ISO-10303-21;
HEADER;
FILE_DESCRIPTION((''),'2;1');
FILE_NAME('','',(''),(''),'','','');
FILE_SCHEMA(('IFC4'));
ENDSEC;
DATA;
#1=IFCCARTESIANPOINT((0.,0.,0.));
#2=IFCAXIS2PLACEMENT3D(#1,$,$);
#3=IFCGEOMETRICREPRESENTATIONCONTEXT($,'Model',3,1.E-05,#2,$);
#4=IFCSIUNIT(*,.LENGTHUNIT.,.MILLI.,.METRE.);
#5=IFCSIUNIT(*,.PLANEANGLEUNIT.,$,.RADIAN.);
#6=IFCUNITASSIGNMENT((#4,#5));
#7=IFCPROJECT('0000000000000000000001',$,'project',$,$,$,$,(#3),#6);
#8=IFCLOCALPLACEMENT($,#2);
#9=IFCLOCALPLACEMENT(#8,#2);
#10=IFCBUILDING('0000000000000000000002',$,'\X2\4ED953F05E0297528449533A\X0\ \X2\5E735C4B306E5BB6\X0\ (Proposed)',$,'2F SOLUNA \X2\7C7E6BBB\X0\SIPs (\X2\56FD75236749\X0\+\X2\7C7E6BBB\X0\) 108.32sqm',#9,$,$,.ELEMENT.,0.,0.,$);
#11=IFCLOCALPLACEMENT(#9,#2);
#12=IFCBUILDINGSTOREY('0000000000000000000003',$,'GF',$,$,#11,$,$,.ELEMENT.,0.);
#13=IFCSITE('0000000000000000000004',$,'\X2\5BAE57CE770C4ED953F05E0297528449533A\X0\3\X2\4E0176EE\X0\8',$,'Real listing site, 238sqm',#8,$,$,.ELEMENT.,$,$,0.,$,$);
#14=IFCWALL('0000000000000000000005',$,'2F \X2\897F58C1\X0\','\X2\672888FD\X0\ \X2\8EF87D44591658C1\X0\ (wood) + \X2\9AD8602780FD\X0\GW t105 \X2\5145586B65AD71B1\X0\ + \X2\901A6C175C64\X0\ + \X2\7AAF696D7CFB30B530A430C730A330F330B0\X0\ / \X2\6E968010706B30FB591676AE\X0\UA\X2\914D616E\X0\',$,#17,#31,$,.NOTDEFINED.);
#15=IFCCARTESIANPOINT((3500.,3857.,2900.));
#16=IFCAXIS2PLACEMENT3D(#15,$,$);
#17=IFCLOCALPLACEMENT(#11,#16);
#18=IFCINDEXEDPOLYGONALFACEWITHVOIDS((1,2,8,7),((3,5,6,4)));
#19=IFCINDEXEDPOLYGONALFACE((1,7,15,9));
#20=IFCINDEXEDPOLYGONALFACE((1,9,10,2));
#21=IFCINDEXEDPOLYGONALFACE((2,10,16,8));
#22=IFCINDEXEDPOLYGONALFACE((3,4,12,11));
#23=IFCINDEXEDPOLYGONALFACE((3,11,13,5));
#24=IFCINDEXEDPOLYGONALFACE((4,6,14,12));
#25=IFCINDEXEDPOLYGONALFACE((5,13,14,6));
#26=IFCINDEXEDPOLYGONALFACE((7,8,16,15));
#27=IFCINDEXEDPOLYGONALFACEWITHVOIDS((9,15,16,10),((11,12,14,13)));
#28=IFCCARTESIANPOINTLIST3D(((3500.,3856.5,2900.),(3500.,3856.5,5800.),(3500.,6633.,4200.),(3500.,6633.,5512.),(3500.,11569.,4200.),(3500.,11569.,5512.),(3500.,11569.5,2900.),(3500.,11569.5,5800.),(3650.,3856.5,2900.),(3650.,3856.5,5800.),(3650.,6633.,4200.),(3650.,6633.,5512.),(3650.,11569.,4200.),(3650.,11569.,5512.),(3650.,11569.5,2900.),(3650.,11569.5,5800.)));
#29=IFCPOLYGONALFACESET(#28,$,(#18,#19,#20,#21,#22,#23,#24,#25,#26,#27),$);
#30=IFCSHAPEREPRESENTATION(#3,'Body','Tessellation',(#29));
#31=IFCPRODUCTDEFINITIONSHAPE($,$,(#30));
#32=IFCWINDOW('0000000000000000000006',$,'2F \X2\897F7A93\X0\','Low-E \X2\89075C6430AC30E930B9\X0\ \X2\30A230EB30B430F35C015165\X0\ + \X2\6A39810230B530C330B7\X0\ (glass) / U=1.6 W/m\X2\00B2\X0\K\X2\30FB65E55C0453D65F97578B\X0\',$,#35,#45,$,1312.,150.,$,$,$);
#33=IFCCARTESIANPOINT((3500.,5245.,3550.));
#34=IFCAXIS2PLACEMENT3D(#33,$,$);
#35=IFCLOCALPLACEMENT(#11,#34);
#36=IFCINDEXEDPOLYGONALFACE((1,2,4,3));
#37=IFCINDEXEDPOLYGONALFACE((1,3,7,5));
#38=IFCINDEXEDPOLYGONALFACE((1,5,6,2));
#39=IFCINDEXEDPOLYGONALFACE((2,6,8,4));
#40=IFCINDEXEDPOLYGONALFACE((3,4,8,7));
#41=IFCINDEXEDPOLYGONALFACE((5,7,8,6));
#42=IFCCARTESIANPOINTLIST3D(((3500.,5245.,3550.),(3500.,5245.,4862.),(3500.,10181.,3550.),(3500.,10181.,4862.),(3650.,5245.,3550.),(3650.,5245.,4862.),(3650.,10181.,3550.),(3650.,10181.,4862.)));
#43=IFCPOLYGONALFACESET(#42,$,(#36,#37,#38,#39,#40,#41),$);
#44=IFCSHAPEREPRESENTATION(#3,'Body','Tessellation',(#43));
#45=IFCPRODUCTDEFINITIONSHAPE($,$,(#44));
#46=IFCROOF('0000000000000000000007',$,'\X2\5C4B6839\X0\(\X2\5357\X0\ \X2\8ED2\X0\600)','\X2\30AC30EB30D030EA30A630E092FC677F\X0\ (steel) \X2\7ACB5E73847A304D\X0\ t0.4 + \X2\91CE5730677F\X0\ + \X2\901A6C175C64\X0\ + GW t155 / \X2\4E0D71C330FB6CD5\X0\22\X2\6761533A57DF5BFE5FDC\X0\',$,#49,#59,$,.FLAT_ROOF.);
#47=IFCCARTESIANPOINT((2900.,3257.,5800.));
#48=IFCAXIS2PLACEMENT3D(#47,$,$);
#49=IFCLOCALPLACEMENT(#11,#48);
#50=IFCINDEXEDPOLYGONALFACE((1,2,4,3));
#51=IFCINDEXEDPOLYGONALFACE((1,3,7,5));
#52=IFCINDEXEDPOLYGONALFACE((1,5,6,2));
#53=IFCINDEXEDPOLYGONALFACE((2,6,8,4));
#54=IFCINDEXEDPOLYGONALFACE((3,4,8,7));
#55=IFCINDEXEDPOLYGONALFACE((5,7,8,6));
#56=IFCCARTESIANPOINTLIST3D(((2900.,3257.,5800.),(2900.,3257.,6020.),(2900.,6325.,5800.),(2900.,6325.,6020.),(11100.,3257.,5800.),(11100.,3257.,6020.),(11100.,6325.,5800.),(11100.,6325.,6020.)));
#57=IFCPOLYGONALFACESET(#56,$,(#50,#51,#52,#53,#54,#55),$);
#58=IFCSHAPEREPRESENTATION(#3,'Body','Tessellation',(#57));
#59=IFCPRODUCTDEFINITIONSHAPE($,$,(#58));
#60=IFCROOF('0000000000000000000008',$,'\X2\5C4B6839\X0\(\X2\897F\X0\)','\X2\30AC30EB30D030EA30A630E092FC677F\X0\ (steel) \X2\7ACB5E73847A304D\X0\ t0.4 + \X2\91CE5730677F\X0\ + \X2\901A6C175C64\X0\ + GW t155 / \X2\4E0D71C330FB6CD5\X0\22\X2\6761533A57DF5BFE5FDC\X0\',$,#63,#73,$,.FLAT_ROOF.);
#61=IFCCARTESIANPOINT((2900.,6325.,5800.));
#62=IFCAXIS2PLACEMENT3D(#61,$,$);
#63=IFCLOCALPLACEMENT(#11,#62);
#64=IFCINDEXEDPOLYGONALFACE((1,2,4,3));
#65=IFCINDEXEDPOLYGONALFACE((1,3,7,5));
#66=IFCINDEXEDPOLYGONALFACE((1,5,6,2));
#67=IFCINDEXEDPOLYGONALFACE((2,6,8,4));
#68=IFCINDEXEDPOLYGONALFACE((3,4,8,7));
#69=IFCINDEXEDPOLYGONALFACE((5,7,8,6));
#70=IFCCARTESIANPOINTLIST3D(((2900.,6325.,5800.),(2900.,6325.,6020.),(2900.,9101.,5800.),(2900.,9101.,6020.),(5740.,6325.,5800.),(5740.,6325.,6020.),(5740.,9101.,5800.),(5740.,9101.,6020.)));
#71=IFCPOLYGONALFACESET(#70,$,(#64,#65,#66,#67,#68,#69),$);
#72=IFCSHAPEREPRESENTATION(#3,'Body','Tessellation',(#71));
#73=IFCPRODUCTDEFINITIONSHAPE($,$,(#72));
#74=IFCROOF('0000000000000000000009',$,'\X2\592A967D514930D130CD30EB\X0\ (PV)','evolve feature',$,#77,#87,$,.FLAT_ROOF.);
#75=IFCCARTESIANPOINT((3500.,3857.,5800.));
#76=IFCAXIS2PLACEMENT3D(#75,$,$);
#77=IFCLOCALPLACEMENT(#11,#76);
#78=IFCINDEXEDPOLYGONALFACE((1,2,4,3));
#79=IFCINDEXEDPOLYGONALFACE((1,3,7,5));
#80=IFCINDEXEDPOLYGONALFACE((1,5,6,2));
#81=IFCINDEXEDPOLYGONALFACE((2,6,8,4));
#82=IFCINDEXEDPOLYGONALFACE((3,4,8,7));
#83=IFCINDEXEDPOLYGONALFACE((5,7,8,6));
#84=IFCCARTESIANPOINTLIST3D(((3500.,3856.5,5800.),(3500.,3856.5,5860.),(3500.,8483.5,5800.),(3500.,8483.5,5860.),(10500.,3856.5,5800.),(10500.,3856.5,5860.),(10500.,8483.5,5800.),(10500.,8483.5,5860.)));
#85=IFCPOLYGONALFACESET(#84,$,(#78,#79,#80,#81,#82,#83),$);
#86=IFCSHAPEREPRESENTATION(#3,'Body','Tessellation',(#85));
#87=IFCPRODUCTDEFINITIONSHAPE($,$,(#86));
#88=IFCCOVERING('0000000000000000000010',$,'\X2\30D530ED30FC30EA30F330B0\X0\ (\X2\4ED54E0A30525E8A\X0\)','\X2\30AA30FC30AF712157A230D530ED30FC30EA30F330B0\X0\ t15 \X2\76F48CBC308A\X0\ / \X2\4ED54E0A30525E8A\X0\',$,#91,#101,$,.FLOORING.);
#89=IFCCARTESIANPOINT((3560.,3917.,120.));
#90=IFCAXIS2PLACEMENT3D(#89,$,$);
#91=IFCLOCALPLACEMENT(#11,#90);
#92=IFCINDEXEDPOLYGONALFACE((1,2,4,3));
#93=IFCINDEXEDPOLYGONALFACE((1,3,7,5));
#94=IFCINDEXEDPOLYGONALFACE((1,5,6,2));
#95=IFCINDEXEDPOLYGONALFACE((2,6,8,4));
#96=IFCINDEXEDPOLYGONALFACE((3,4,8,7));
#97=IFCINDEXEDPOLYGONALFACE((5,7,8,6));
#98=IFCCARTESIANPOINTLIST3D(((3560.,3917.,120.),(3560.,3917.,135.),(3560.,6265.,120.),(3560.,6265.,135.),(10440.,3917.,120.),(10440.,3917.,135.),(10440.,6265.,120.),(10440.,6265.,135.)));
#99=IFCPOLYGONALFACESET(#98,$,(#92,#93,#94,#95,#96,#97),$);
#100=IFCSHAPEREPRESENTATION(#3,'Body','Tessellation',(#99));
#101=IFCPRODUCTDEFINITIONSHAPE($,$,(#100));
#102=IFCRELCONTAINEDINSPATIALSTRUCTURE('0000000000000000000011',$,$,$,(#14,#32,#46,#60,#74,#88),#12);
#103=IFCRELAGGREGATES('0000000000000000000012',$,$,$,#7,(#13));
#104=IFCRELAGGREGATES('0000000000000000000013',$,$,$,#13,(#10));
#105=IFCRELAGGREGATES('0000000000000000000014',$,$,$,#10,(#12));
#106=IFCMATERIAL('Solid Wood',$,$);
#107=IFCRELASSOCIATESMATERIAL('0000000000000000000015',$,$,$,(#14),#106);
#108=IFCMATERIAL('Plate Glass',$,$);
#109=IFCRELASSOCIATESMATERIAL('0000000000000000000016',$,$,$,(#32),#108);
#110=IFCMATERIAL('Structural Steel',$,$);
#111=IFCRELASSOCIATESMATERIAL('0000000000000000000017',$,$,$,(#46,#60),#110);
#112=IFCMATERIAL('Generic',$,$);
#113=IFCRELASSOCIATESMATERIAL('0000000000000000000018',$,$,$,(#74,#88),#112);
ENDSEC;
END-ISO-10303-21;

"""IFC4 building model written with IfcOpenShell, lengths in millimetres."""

from ifc_helpers import new_model, si_unit, frame, frame_2d, origin, place, context, project, spatial, rectangle, extrude, material, element, fill, save


model = new_model("IFC4")

# Units and contexts
model_context = context("Model", 3, precision=1e-05, world=origin())
ifc_project = project(units=[si_unit("LENGTHUNIT", "METRE", prefix="MILLI"), si_unit("PLANEANGLEUNIT", "RADIAN")], contexts=[model_context])

# Site, building, storey
site_placement = place(None, origin())
site = spatial("IfcSite", under=ifc_project, at=site_placement, Name="宮城県仙台市青葉区3丁目8", ObjectType="Real listing site, 238sqm", CompositionType="ELEMENT", RefElevation=0.0)
building_placement = place(site_placement, origin())
building = spatial("IfcBuilding", under=site, at=building_placement, Name="仙台市青葉区 平屋の家 (Proposed)", ObjectType="2F SOLUNA 籾殻SIPs (国産杉+籾殻) 108.32sqm", CompositionType="ELEMENT", ElevationOfRefHeight=0.0, ElevationOfTerrain=0.0)
storey_placement = place(building_placement, origin())
storey = spatial("IfcBuildingStorey", under=building, at=storey_placement, Name="GF", CompositionType="ELEMENT", Elevation=0.0)

# Shared definitions
ifc_material_1 = material(Name="Solid Wood")
ifc_material_2 = material(Name="Generic")

# Shared definitions
ifc_material_3 = material(Name="Plate Glass")

# Wall, opening, window
wall_1_placement = place(storey_placement, frame((3500.0, 3857.0, 2900.0)))
wall_1 = element("IfcWall", 1, at=wall_1_placement, inside=storey, material=ifc_material_1, Name="2F 西壁", Description="木製 軸組外壁 (wood) + 高性能GW t105 充填断熱 + 通気層 + 窯業系サイディング / 準耐火・外皮UA配慮", PredefinedType="NOTDEFINED", context=model_context, shape_type="SweptSolid", body=[
    extrude(rectangle(XDim=150.0, YDim=7713.0, at=frame_2d((75.0, 3856.0))), frame((3500.0, 3857.0, 2900.0)), (0.0, 0.0, 1.0), 2900.0),
])
opening_1_placement = place(storey_placement, frame((3500.0, 5245.0, 3550.0)))
opening_1 = element("IfcOpeningElement", 2, at=opening_1_placement, cuts=wall_1, PredefinedType="NOTDEFINED", context=model_context, shape_type="SweptSolid", body=[
    extrude(rectangle(XDim=150.0, YDim=4936.0, at=frame_2d((75.0, 2468.0))), frame((3500.0, 5245.0, 3550.0)), (0.0, 0.0, 1.0), 1312.0),
])
window_1_placement = place(storey_placement, frame((3500.0, 5245.0, 3550.0)))
window_1 = element("IfcWindow", 3, at=window_1_placement, inside=storey, material=ifc_material_3, Name="2F 西窓", Description="Low-E 複層ガラス アルゴン封入 + 樹脂サッシ (glass) / U=1.6 W/m²K・日射取得型", OverallHeight=1312.0, OverallWidth=150.0, context=model_context, shape_type="SweptSolid", body=[
    extrude(rectangle(XDim=150.0, YDim=4936.0, at=frame_2d((75.0, 2468.0))), frame((3500.0, 5245.0, 3550.0)), (0.0, 0.0, 1.0), 1312.0),
])
fill(opening_1, window_1)

# Roofs
ifc_material_4 = material(Name="Structural Steel")
roof_1_placement = place(storey_placement, frame((2900.0, 3257.0, 5800.0)))
element("IfcRoof", 4, at=roof_1_placement, inside=storey, material=ifc_material_4, Name="屋根(南 軒600)", Description="ガルバリウム鋼板 (steel) 立平葺き t0.4 + 野地板 + 通気層 + GW t155 / 不燃・法22条区域対応", PredefinedType="FLAT_ROOF", context=model_context, shape_type="SweptSolid", body=[
    extrude(rectangle(XDim=8200.0, YDim=3068.0, at=frame_2d((4100.0, 1534.0))), frame((2900.0, 3257.0, 5800.0)), (0.0, 0.0, 1.0), 220.0),
])
roof_2_placement = place(storey_placement, frame((2900.0, 6325.0, 5800.0)))
element("IfcRoof", 5, at=roof_2_placement, inside=storey, material=ifc_material_4, Name="屋根(西)", Description="ガルバリウム鋼板 (steel) 立平葺き t0.4 + 野地板 + 通気層 + GW t155 / 不燃・法22条区域対応", PredefinedType="FLAT_ROOF", context=model_context, shape_type="SweptSolid", body=[
    extrude(rectangle(XDim=2840.0, YDim=2776.0, at=frame_2d((1420.0, 1388.0))), frame((2900.0, 6325.0, 5800.0)), (0.0, 0.0, 1.0), 220.0),
])
roof_3_placement = place(storey_placement, frame((3500.0, 3857.0, 5800.0)))
element("IfcRoof", 6, at=roof_3_placement, inside=storey, material=ifc_material_2, Name="太陽光パネル (PV)", Description="evolve feature", PredefinedType="FLAT_ROOF", context=model_context, shape_type="SweptSolid", body=[
    extrude(rectangle(XDim=7000.0, YDim=4627.0, at=frame_2d((3500.0, 2313.0))), frame((3500.0, 3857.0, 5800.0)), (0.0, 0.0, 1.0), 60.0),
])

# Covering
covering_placement = place(storey_placement, frame((3560.0, 3917.0, 120.0)))
element("IfcCovering", 7, at=covering_placement, inside=storey, material=ifc_material_2, Name="フローリング (仕上げ床)", Description="オーク無垢フローリング t15 直貼り / 仕上げ床", PredefinedType="FLOORING", context=model_context, shape_type="SweptSolid", body=[
    extrude(rectangle(XDim=6880.0, YDim=2348.0, at=frame_2d((3440.0, 1174.0))), frame((3560.0, 3917.0, 120.0)), (0.0, 0.0, 1.0), 15.0),
])

save(model, "model.ifc")
